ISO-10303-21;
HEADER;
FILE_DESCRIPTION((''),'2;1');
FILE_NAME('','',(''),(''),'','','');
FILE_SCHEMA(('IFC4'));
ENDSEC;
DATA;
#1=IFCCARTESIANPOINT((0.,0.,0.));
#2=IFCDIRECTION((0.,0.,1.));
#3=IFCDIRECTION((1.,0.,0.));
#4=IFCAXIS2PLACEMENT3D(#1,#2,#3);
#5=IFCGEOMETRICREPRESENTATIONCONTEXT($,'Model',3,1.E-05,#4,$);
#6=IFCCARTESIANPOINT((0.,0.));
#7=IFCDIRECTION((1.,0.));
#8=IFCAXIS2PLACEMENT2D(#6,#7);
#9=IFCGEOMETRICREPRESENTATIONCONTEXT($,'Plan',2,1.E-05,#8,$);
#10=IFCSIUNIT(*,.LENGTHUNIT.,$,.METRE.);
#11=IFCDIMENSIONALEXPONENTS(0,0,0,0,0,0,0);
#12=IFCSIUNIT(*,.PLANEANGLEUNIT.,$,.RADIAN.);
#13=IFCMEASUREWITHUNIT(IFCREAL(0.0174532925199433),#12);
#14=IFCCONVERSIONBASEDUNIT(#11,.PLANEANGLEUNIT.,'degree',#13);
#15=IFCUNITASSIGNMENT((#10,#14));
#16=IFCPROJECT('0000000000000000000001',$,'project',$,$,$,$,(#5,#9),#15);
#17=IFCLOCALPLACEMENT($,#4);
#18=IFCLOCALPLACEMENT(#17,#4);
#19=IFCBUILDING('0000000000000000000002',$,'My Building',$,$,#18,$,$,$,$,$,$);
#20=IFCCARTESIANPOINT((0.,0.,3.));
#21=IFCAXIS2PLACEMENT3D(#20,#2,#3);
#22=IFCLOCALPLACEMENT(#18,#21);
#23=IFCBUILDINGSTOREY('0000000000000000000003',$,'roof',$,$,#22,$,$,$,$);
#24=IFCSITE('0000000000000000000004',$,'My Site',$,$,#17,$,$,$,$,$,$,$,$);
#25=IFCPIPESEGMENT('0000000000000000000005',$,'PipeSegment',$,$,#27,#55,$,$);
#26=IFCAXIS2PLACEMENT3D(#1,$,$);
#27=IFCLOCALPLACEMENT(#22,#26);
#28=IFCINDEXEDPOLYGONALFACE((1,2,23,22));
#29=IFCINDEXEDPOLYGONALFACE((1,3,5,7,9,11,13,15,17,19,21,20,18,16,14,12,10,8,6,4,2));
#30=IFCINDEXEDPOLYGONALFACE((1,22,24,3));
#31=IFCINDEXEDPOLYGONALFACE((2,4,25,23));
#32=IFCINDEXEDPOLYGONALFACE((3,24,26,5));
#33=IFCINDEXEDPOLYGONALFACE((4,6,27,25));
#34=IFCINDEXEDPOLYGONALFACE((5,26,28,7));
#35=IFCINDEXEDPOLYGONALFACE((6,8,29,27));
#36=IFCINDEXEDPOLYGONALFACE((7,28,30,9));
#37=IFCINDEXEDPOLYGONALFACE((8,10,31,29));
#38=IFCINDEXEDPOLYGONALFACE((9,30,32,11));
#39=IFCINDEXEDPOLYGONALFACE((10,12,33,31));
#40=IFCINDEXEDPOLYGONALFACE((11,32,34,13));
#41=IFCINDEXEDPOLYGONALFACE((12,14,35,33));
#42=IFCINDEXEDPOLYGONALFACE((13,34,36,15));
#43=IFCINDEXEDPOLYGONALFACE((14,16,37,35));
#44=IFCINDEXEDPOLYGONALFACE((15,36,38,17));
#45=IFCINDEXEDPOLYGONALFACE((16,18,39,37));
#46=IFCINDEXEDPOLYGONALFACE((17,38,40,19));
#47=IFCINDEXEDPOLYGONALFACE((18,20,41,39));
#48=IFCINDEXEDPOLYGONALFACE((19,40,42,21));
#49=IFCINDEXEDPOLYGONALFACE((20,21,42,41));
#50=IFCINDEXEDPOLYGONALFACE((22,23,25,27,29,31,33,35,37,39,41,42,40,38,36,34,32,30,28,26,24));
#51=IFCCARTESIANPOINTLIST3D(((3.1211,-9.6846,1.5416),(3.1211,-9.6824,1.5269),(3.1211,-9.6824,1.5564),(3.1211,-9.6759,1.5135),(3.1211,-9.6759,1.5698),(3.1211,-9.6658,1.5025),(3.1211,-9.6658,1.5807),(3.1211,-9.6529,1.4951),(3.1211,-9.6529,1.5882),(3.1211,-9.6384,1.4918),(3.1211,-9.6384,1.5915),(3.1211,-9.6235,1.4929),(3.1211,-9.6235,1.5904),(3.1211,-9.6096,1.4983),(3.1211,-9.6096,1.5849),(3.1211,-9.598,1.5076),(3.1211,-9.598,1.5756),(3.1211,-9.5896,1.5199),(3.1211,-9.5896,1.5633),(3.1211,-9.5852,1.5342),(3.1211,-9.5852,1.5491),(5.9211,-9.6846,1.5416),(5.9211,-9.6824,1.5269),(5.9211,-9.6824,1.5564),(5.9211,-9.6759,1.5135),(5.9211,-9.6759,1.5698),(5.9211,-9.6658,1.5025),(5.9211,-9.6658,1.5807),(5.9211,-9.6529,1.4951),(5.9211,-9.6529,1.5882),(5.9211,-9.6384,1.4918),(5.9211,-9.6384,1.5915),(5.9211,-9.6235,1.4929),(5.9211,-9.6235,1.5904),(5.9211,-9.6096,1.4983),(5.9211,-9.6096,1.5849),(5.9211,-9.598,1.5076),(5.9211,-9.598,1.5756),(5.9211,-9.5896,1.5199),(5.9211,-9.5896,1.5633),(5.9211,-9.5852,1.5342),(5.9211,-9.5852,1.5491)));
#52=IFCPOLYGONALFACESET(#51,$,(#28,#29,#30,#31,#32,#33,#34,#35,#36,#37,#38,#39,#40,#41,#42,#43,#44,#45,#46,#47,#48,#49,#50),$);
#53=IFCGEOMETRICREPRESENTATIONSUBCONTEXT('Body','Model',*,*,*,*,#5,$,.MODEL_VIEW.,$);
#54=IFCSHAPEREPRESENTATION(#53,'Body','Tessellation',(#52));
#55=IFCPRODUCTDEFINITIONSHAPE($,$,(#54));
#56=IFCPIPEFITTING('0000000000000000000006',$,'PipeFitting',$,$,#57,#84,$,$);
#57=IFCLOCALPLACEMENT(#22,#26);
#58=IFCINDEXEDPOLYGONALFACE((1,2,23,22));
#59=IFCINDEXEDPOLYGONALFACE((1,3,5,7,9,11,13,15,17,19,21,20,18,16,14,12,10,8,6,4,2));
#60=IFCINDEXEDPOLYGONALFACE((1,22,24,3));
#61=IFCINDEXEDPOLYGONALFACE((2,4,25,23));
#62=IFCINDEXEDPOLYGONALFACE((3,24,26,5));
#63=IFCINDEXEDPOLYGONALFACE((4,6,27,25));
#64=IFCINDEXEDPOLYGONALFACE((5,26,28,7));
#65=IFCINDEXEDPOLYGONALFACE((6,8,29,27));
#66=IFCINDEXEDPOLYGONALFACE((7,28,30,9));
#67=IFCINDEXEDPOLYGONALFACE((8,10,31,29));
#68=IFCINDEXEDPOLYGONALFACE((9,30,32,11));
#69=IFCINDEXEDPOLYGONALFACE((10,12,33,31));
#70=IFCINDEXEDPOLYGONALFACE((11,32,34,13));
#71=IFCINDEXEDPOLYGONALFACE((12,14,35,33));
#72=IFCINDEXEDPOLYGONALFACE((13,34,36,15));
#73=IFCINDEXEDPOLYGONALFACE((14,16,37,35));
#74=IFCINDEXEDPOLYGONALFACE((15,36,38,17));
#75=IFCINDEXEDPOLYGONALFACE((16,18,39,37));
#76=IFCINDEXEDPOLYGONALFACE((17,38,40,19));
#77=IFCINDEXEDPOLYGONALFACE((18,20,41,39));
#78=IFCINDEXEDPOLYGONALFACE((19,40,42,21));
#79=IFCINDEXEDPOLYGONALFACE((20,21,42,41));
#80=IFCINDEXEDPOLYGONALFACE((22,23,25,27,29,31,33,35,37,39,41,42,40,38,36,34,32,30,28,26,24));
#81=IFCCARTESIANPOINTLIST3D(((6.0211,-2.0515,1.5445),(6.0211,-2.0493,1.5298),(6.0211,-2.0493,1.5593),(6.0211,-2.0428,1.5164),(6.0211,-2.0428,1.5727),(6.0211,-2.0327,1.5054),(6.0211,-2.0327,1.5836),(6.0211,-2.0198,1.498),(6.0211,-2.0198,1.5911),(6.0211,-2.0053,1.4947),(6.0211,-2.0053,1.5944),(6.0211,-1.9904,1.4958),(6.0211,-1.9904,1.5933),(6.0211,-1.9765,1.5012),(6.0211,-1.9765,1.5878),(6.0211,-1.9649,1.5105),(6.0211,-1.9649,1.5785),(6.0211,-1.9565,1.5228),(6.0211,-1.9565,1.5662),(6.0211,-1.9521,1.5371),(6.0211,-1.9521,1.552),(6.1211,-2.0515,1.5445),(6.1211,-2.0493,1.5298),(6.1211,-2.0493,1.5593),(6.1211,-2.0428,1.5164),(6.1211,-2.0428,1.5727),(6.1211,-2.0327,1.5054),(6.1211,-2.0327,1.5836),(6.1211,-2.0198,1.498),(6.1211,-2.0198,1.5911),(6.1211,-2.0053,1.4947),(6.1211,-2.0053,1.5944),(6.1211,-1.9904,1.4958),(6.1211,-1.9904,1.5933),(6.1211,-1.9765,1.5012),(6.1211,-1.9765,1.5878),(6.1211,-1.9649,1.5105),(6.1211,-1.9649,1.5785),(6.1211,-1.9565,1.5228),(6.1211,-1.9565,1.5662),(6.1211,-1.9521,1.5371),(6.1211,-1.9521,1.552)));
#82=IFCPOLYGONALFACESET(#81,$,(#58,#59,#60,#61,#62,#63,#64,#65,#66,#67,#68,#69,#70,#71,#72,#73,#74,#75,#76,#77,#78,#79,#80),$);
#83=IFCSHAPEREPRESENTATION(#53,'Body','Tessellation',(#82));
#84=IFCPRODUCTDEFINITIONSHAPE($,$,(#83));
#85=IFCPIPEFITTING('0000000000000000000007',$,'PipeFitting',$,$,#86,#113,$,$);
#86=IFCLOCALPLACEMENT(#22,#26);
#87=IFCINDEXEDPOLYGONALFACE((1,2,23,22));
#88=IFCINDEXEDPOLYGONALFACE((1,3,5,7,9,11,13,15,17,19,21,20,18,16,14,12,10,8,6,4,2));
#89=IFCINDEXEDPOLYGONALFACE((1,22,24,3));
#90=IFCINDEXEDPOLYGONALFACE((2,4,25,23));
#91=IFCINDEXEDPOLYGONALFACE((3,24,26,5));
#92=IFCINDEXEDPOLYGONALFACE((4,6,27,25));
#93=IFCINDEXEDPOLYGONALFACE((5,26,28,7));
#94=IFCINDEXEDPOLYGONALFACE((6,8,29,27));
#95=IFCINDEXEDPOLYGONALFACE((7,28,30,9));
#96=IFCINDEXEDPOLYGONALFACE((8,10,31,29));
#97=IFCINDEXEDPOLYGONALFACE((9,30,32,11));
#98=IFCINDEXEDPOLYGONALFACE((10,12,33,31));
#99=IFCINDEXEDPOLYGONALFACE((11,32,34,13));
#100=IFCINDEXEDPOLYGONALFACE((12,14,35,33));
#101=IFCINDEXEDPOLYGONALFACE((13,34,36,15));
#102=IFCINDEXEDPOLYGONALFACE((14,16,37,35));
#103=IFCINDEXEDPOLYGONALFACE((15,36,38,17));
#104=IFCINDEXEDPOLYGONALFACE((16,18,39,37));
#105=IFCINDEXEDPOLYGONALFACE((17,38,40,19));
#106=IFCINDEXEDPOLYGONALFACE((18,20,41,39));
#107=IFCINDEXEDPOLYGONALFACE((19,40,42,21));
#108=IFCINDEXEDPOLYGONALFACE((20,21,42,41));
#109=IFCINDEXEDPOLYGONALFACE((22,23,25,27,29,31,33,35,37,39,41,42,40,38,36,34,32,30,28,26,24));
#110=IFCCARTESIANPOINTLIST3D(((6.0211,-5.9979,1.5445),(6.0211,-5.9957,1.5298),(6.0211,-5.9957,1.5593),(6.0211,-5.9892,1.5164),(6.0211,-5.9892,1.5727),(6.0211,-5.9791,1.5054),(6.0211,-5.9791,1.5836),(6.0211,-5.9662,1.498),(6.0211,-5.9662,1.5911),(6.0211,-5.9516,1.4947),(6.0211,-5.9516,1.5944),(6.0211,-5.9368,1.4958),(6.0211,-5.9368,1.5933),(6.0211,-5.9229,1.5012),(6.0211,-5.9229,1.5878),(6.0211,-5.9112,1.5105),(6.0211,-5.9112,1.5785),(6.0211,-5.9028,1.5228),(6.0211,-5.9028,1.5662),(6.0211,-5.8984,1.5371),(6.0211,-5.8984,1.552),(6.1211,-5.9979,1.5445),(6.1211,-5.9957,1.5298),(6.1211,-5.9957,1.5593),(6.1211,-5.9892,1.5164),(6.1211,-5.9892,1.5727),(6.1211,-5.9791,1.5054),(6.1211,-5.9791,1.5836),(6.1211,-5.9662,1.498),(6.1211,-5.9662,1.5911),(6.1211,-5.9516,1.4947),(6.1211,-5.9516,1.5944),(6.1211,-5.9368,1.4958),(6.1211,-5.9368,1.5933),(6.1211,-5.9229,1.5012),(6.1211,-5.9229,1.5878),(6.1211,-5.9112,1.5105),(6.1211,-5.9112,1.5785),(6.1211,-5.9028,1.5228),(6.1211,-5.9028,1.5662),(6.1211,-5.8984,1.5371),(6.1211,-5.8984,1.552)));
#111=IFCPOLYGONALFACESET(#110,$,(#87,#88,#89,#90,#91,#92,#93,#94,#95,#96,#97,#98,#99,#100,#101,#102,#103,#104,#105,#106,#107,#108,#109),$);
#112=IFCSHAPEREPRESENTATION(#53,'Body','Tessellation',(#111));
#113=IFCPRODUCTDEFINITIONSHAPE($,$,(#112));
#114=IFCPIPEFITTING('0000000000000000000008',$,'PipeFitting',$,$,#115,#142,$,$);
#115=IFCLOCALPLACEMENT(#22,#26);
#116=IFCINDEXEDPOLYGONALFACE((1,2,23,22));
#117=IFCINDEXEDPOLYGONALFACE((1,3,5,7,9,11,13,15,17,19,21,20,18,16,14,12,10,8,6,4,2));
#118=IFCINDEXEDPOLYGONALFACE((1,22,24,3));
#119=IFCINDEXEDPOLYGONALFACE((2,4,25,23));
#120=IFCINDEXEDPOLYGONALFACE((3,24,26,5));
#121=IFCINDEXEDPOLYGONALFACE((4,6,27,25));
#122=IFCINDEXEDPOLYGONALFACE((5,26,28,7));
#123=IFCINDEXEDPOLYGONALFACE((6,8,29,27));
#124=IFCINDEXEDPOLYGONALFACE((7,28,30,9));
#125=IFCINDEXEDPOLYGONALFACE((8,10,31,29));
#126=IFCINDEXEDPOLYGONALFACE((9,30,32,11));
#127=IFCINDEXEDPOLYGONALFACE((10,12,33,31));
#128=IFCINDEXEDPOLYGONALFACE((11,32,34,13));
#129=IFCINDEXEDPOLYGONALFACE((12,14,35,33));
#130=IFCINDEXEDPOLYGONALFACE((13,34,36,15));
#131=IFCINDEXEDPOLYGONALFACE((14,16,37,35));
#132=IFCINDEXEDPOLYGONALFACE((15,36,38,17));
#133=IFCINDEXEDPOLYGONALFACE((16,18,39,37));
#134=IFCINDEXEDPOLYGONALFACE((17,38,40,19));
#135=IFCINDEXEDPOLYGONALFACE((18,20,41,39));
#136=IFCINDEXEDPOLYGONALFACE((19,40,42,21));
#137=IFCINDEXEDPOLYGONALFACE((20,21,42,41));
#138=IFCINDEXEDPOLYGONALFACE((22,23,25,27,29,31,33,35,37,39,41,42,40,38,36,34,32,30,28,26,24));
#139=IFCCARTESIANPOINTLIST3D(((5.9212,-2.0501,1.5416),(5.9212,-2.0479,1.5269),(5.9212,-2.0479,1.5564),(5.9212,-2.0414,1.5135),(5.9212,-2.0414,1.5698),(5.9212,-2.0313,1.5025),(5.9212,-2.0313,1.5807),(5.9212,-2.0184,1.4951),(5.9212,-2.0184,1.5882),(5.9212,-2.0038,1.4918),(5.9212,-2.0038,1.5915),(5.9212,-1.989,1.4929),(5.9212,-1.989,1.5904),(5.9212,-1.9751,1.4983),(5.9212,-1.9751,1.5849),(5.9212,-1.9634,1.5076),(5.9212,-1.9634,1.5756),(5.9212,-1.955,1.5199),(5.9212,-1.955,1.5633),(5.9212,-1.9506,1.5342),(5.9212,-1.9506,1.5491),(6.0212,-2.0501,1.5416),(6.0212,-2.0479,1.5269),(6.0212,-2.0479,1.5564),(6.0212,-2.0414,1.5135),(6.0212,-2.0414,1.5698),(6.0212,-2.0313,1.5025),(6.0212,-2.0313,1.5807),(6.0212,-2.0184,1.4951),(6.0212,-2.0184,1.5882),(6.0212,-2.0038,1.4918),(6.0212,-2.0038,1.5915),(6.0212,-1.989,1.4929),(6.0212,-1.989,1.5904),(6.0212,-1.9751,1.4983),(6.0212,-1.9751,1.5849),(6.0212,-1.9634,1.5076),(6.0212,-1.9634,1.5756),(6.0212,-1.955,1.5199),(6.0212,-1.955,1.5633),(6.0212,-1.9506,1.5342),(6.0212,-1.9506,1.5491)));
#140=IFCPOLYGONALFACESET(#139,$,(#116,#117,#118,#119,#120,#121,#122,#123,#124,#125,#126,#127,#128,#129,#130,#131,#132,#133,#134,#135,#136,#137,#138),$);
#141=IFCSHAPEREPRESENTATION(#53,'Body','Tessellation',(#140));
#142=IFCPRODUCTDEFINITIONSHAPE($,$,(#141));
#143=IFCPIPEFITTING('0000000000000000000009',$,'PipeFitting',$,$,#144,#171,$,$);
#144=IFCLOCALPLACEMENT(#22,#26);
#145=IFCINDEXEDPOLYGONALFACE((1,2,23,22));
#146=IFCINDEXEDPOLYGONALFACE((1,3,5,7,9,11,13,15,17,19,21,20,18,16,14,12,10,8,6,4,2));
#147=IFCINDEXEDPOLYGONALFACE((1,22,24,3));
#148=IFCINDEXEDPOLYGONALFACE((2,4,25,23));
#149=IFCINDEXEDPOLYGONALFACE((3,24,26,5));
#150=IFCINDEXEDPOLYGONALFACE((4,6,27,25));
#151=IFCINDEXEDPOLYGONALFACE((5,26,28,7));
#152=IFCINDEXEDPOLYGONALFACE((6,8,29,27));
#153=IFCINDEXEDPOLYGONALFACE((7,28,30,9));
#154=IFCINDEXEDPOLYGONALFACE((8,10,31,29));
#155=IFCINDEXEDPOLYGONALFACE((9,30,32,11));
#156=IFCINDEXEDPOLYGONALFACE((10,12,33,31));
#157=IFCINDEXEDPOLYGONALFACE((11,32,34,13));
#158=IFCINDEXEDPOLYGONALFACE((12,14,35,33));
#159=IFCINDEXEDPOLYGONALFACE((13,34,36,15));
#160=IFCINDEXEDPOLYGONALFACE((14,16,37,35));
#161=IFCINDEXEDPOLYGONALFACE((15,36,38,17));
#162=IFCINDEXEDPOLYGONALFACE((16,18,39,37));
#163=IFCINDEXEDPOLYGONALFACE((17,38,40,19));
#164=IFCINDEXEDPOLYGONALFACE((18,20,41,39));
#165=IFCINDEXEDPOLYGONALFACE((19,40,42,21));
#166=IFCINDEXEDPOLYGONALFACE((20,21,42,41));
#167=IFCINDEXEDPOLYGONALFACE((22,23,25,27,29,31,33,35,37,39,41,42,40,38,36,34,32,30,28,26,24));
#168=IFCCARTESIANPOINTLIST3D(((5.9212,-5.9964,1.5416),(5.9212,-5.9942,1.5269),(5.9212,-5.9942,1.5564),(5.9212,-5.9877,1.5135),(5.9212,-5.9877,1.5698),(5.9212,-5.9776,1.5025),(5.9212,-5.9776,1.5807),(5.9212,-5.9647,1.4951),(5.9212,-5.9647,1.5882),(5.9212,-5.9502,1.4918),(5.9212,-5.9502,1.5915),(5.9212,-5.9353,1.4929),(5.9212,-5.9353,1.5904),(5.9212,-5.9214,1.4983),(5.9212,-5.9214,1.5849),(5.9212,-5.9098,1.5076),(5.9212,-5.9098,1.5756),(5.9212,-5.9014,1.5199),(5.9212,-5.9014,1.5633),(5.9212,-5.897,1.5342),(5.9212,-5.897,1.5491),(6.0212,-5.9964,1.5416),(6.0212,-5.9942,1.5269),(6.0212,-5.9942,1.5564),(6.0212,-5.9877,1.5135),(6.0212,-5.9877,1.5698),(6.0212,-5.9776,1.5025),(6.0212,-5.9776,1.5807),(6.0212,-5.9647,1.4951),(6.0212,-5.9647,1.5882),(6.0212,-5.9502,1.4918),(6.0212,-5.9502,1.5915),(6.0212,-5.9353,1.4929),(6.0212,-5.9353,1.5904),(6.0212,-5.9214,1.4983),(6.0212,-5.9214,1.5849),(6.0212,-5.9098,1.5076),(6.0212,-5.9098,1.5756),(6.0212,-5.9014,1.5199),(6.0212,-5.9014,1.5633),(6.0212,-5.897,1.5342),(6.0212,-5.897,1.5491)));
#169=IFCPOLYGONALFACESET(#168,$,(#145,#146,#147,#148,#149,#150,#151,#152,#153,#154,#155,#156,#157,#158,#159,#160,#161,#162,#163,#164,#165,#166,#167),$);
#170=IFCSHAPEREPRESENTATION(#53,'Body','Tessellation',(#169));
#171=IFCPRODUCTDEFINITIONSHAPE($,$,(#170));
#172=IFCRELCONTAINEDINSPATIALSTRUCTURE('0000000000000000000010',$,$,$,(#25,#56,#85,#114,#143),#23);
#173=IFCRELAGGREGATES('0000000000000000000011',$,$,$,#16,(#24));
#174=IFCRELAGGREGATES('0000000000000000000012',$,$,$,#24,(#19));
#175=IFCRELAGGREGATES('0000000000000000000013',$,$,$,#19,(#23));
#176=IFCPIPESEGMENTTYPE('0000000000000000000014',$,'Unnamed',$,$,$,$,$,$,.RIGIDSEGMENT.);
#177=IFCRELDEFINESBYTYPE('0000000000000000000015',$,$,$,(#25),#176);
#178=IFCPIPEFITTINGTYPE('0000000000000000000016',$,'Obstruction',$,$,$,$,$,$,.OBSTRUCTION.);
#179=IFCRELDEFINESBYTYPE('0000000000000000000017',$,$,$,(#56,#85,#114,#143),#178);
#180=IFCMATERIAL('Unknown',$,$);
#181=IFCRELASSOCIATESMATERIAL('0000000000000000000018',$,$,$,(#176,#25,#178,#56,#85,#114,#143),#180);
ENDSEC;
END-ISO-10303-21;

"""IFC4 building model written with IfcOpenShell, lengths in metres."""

from ifc_helpers import new_model, entity, si_unit, converted_unit, frame, origin_with_axes, origin_2d_with_axis, place, context, subcontext, project, spatial, circle, extrude, material, material_profile, profile_set, profile_usage, type_object, element, save


model = new_model("IFC4")

# Units and contexts
model_context = context("Model", 3, precision=1e-05, world=origin_with_axes())
plan_context = context("Plan", 2, precision=1e-05, world=origin_2d_with_axis())
body_context = subcontext(model_context, "Body", "Model", "MODEL_VIEW")
ifc_project = project(units=[si_unit("LENGTHUNIT", "METRE"), converted_unit("PLANEANGLEUNIT", "degree", entity("IfcReal", 0.0174532925199433), si_unit("PLANEANGLEUNIT", "RADIAN"), dimensions=[0, 0, 0, 0, 0, 0, 0])], contexts=[model_context, plan_context])

# Site, building, storey
site_placement = place(None, origin_with_axes())
site = spatial("IfcSite", under=ifc_project, at=site_placement, Name="My Site")
building_placement = place(site_placement, origin_with_axes())
building = spatial("IfcBuilding", under=site, at=building_placement, Name="My Building")
storey_placement = place(building_placement, frame((0.0, 0.0, 3.0), z_axis=(0.0, 0.0, 1.0), x_axis=(1.0, 0.0, 0.0)))
storey = spatial("IfcBuildingStorey", under=building, at=storey_placement, Name="roof")

# Shared definitions
ifc_material = material(Name="Unknown")

# Pipe segment
ifc_material_profile_1 = material_profile(ifc_material, circle(Radius=0.05))
ifc_profile_set_1 = profile_set([ifc_material_profile_1])
pipe_segment_type = type_object("IfcPipeSegmentType", Name="Unnamed", PredefinedType="RIGIDSEGMENT", material=ifc_profile_set_1)
ifc_profile_usage_1 = profile_usage(ifc_profile_set_1, cardinal=5)
pipe_segment_1_placement = place(storey_placement, frame((5.9211, -9.6346, 1.5416), z_axis=(-1.0, 0.0, 0.0), x_axis=(0.0, -1.0, 0.0)))
element("IfcPipeSegment", 1, at=pipe_segment_1_placement, inside=storey, type_object=pipe_segment_type, material=ifc_profile_usage_1, Name="PipeSegment", context=body_context, shape_type="SweptSolid", body=[
    extrude(circle(Radius=0.05), origin_with_axes(), (0.0, 0.0, 1.0), 2.8),
])

# Pipe fittings
ifc_material_profile_2 = material_profile(ifc_material, circle(Radius=0.05))
ifc_profile_set_2 = profile_set([ifc_material_profile_2])
ifc_profile_usage_2 = profile_usage(ifc_profile_set_2, cardinal=5)
pipe_fitting_type_1 = type_object("IfcPipeFittingType", Name="Obstruction", PredefinedType="OBSTRUCTION", material=ifc_profile_set_2)
pipe_fitting_1_placement = place(storey_placement, frame((6.0211, -2.0015, 1.5445), z_axis=(1.0, 0.0, 0.0), x_axis=(0.0, -1.0, 0.0)))
element("IfcPipeFitting", 2, at=pipe_fitting_1_placement, inside=storey, type_object=pipe_fitting_type_1, material=ifc_profile_usage_2, Name="PipeFitting", context=body_context, shape_type="SweptSolid", body=[
    extrude(circle(Radius=0.05), origin_with_axes(), (0.0, 0.0, 1.0), 0.1),
])
ifc_profile_usage_3 = profile_usage(ifc_profile_set_2, cardinal=5)
pipe_fitting_2_placement = place(storey_placement, frame((6.0211, -5.9479, 1.5445), z_axis=(1.0, 0.0, 0.0), x_axis=(0.0, -1.0, 0.0)))
element("IfcPipeFitting", 3, at=pipe_fitting_2_placement, inside=storey, type_object=pipe_fitting_type_1, material=ifc_profile_usage_3, Name="PipeFitting", context=body_context, shape_type="SweptSolid", body=[
    extrude(circle(Radius=0.05), origin_with_axes(), (0.0, 0.0, 1.0), 0.1),
])
ifc_profile_usage_4 = profile_usage(ifc_profile_set_2, cardinal=5)
pipe_fitting_3_placement = place(storey_placement, frame((6.0212, -2.0001, 1.5416), z_axis=(-1.0, 0.0, 0.0), x_axis=(0.0, -1.0, 0.0)))
element("IfcPipeFitting", 4, at=pipe_fitting_3_placement, inside=storey, type_object=pipe_fitting_type_1, material=ifc_profile_usage_4, Name="PipeFitting", context=body_context, shape_type="SweptSolid", body=[
    extrude(circle(Radius=0.05), origin_with_axes(), (0.0, 0.0, 1.0), 0.1),
])
ifc_profile_usage_5 = profile_usage(ifc_profile_set_2, cardinal=5)
pipe_fitting_4_placement = place(storey_placement, frame((6.0212, -5.9464, 1.5416), z_axis=(-1.0, 0.0, 0.0), x_axis=(0.0, -1.0, 0.0)))
element("IfcPipeFitting", 5, at=pipe_fitting_4_placement, inside=storey, type_object=pipe_fitting_type_1, material=ifc_profile_usage_5, Name="PipeFitting", context=body_context, shape_type="SweptSolid", body=[
    extrude(circle(Radius=0.05), origin_with_axes(), (0.0, 0.0, 1.0), 0.1),
])

save(model, "model.ifc")
